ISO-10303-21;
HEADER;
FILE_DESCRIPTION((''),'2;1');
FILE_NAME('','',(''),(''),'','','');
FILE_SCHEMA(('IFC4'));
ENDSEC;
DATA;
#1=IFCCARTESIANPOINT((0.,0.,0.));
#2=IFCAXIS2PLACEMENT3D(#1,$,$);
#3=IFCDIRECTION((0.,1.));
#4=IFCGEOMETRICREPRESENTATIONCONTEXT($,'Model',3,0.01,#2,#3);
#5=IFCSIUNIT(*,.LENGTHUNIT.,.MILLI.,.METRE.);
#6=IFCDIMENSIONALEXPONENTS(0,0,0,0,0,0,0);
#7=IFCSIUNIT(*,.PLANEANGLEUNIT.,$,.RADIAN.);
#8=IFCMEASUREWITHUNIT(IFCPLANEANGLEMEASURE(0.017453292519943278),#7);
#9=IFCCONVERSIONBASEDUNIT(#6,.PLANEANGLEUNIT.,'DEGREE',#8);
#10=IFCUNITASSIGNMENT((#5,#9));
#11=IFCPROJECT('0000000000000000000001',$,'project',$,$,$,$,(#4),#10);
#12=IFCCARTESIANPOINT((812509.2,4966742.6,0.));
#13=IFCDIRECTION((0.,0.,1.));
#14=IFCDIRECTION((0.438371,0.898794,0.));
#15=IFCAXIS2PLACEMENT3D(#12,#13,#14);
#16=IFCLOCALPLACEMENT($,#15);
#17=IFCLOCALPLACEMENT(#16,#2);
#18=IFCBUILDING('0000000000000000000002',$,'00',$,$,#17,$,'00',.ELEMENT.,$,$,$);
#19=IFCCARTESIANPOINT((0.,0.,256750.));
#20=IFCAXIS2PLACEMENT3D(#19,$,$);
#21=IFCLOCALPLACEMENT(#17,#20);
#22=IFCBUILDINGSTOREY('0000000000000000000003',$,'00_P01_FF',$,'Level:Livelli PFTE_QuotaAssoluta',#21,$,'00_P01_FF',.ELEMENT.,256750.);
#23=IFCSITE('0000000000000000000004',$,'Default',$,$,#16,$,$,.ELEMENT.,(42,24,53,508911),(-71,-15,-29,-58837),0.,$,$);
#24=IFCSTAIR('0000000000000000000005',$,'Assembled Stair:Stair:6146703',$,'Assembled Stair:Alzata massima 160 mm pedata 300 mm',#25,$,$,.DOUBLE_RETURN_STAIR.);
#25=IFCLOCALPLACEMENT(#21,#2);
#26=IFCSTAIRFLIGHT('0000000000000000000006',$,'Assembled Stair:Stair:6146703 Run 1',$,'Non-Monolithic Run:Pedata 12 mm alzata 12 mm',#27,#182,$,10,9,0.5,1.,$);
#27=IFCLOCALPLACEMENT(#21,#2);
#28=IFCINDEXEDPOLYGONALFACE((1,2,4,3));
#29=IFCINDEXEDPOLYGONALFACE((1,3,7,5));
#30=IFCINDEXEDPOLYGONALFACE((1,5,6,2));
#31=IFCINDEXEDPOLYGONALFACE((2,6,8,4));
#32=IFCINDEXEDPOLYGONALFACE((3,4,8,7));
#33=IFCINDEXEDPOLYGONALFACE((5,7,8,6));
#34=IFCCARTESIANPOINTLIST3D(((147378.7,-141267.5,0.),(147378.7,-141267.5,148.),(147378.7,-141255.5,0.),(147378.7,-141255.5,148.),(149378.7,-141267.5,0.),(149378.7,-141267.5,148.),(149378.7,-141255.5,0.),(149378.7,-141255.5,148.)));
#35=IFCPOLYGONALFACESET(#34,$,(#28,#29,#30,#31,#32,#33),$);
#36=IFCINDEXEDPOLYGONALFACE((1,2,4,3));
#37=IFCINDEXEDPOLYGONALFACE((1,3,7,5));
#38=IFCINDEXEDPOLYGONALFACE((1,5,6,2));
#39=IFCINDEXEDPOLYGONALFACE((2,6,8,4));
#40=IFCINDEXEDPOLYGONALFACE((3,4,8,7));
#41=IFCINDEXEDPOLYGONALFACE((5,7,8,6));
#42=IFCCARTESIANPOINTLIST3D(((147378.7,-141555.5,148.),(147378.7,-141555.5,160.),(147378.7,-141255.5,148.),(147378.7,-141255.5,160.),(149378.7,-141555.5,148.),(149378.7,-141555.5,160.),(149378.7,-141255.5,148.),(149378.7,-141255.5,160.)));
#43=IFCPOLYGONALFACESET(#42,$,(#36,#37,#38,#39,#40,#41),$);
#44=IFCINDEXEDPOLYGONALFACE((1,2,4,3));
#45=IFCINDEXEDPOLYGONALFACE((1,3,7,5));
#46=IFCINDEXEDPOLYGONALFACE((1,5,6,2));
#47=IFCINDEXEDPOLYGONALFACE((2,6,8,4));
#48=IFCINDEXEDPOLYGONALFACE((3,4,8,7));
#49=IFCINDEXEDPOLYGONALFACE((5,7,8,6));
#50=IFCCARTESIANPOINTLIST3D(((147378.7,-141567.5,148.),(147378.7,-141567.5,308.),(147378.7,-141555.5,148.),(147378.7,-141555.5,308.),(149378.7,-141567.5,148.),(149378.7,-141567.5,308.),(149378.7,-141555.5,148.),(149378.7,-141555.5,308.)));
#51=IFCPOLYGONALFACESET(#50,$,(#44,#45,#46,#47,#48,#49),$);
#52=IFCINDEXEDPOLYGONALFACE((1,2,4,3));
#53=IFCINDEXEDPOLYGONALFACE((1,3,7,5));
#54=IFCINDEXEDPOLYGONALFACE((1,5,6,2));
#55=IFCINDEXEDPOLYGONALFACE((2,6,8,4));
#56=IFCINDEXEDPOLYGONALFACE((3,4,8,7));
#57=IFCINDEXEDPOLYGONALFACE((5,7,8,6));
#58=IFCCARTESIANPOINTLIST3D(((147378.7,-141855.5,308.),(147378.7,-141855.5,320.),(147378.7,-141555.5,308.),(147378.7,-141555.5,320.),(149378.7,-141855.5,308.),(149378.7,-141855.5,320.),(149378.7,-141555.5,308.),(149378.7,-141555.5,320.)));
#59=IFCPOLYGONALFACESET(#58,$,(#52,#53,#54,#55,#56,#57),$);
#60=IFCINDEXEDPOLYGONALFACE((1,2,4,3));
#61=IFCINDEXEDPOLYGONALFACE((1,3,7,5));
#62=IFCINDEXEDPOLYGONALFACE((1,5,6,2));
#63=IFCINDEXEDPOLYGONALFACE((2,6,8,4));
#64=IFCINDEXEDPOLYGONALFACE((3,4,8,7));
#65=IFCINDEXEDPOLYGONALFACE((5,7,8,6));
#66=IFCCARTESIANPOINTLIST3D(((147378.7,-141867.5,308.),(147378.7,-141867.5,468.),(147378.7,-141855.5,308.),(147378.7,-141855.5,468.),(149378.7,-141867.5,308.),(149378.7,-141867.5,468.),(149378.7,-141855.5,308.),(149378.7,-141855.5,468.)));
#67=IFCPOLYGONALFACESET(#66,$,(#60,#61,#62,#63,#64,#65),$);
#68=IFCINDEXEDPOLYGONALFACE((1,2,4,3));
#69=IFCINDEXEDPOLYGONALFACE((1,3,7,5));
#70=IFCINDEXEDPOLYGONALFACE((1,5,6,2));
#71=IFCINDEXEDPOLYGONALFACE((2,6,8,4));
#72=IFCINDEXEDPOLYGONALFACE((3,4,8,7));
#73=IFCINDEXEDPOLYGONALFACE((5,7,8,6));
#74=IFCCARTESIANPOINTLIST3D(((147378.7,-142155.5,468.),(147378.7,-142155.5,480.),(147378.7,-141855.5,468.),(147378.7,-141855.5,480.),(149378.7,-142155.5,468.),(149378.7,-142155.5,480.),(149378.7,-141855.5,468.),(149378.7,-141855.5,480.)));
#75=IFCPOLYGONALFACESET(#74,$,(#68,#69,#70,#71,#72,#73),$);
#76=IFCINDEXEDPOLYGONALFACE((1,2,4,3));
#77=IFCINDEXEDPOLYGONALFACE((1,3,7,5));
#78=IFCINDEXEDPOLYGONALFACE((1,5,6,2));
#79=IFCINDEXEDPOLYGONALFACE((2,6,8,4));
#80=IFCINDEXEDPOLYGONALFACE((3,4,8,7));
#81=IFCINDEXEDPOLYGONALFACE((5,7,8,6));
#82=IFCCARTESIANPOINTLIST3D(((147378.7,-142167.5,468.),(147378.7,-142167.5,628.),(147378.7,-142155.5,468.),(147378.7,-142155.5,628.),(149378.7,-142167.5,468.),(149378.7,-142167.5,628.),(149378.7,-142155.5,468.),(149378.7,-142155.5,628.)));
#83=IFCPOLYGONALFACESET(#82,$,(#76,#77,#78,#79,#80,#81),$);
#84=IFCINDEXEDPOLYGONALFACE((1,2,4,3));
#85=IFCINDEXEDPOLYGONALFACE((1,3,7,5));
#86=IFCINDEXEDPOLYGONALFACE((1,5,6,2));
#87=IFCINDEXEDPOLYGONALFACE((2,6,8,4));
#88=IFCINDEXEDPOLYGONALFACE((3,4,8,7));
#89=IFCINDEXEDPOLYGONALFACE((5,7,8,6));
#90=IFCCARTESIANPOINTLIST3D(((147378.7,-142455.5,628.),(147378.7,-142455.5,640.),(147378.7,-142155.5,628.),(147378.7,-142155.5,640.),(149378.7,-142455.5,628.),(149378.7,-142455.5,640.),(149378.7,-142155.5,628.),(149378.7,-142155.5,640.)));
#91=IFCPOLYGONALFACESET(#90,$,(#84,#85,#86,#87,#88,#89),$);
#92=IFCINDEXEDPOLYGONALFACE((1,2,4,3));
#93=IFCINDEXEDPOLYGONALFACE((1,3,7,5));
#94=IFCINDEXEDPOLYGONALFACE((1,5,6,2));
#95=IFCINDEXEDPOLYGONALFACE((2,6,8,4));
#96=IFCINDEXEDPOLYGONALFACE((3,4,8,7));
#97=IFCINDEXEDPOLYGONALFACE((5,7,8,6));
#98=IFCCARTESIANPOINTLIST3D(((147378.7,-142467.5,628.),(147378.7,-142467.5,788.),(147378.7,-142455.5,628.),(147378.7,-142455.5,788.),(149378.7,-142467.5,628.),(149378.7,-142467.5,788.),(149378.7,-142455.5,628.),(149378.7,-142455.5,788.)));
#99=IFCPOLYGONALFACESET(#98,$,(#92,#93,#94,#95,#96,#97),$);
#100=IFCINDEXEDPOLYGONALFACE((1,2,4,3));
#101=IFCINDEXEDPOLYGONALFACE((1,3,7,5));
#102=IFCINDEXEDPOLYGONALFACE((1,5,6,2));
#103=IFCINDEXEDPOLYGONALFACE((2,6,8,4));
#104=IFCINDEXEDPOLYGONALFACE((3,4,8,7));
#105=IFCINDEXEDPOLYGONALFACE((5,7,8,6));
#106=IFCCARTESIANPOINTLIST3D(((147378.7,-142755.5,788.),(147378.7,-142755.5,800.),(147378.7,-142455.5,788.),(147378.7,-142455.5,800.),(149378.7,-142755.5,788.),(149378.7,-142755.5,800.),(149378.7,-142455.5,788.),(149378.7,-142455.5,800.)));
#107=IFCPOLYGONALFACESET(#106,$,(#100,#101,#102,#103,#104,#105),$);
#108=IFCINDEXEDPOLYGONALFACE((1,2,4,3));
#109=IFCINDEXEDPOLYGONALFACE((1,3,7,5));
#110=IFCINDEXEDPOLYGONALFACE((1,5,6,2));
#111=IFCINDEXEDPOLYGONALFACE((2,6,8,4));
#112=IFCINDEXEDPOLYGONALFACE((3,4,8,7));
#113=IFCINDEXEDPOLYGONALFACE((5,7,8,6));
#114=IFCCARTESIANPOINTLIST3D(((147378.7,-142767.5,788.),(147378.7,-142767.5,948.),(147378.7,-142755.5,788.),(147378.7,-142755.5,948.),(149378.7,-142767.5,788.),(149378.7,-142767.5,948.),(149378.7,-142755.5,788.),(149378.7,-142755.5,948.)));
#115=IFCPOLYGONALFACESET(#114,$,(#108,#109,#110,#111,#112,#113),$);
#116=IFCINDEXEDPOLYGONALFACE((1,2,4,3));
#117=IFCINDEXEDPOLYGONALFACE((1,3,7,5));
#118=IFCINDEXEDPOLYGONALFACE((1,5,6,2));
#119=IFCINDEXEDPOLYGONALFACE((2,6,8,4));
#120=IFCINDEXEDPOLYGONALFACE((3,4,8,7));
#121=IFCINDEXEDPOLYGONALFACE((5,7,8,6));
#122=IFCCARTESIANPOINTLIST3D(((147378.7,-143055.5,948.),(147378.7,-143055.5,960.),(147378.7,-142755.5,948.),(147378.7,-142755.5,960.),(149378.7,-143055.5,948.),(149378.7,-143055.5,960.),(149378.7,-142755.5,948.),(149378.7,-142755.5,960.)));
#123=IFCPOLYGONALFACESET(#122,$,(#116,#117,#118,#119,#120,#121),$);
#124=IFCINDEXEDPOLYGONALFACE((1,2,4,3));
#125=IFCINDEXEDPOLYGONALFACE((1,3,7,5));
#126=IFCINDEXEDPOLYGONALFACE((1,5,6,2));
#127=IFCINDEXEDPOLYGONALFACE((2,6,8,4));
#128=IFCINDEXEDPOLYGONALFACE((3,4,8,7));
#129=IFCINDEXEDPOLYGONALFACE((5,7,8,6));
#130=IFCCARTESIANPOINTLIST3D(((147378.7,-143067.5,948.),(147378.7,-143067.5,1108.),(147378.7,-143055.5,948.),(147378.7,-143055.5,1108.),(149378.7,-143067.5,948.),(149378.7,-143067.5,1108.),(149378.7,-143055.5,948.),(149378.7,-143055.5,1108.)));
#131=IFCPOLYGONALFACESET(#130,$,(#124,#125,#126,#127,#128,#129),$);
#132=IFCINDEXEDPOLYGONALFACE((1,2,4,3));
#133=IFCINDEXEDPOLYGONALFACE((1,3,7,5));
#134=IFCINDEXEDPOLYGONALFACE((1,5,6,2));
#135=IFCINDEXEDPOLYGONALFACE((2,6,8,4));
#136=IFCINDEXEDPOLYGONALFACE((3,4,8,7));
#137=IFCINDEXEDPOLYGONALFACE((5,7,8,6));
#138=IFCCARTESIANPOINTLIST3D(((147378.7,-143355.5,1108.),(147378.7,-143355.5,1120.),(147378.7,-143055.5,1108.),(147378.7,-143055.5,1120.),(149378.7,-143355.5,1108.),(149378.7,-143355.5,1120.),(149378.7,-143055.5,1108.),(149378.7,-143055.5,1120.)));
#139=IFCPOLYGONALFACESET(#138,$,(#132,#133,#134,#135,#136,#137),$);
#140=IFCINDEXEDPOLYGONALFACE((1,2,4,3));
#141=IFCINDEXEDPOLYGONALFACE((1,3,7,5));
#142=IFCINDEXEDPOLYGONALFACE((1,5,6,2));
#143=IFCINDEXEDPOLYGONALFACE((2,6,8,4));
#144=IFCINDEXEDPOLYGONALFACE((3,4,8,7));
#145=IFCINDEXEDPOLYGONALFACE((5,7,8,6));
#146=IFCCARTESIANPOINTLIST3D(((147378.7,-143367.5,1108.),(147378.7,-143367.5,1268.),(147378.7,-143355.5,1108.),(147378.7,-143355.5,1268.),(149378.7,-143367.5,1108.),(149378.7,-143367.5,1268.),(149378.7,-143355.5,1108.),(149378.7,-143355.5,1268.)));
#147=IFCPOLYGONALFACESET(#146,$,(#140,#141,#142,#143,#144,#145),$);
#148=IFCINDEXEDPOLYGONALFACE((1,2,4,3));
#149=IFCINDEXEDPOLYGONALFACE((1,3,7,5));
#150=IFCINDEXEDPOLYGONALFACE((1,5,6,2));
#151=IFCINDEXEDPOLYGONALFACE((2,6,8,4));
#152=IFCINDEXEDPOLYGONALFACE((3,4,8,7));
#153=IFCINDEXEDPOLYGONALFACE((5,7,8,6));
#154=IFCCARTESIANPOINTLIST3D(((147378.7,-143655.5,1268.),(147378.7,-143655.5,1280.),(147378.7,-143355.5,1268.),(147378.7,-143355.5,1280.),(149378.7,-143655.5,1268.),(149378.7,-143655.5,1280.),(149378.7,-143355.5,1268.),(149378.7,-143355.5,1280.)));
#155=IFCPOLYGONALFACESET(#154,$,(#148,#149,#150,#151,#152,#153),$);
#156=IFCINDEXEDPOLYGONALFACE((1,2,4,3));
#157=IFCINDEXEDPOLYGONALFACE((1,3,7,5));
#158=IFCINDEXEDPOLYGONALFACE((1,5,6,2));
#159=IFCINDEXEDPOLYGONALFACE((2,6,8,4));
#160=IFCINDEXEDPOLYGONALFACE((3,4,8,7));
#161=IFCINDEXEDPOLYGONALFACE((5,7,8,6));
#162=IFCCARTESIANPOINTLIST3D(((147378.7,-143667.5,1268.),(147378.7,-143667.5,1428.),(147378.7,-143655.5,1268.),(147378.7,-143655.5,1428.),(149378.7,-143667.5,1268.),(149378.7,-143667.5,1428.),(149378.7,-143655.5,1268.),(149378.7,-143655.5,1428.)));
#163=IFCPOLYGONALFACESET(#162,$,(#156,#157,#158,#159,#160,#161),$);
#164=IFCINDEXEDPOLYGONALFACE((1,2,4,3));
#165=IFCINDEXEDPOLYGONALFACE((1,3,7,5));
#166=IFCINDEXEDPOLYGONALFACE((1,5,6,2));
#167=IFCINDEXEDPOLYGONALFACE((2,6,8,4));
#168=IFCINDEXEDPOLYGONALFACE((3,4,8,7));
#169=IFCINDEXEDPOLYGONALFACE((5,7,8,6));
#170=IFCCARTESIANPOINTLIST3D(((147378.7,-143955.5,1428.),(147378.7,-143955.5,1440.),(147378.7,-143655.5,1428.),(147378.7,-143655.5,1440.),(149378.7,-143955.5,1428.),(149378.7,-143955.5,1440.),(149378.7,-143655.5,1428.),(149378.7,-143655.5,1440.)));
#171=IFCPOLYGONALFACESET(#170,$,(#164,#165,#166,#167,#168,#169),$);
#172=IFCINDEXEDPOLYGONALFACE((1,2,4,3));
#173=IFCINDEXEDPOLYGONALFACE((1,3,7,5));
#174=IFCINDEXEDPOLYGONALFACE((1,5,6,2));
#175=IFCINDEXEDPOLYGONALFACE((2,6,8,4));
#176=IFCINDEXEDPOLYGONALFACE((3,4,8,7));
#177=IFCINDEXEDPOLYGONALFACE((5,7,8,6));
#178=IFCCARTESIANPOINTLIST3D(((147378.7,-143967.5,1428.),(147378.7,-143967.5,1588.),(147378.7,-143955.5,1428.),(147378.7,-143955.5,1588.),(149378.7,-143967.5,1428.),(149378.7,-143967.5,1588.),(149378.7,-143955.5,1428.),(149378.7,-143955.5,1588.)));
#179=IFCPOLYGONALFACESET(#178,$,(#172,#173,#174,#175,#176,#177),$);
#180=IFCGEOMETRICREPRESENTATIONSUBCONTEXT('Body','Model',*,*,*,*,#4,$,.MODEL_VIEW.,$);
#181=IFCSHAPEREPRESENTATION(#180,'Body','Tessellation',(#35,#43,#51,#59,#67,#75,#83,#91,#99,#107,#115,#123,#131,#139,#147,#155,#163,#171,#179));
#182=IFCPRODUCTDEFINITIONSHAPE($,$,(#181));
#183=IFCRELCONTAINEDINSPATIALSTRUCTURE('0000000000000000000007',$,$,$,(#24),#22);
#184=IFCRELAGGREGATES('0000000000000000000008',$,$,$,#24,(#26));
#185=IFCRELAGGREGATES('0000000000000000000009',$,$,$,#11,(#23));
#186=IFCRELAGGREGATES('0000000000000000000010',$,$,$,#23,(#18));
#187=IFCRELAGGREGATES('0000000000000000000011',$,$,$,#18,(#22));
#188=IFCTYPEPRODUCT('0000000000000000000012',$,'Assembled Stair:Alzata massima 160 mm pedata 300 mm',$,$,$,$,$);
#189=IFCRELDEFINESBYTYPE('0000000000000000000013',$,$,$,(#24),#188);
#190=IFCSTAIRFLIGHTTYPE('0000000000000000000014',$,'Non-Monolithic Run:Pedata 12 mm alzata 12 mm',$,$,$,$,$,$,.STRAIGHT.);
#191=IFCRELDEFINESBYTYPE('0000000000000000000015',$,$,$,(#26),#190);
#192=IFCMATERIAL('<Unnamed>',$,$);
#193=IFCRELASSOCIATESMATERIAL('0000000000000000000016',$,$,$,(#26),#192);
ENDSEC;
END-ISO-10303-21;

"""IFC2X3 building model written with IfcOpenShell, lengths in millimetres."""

from ifc_helpers import new_model, entity, si_unit, converted_unit, direction, frame, frame_2d, origin, origin_2d_with_axis, place, context, subcontext, project, spatial, rectangle, extrude, material, type_object, element, aggregate, save


model = new_model("IFC2X3")

# Units and contexts
model_context = context("Model", 3, precision=0.01, world=origin(), true_north=direction((0.0, 1.0)))
body_context = subcontext(model_context, "Body", "Model", "MODEL_VIEW")
ifc_project = project(units=[si_unit("LENGTHUNIT", "METRE", prefix="MILLI"), converted_unit("PLANEANGLEUNIT", "DEGREE", entity("IfcPlaneAngleMeasure", 0.017453292519943278), si_unit("PLANEANGLEUNIT", "RADIAN"), dimensions=[0, 0, 0, 0, 0, 0, 0])], contexts=[model_context])

# Site, building, storey
site_placement = place(None, frame((812509.2, 4966742.6, 0.0), z_axis=(0.0, 0.0, 1.0), x_axis=(0.438371, 0.898794, 0.0)))
site = spatial("IfcSite", under=ifc_project, at=site_placement, Name="Default", CompositionType="ELEMENT", RefLatitude=(42, 24, 53, 508911), RefLongitude=(-71, -15, -29, -58837), RefElevation=0.0)
building_placement = place(site_placement, origin())
building = spatial("IfcBuilding", under=site, at=building_placement, Name="00", LongName="00", CompositionType="ELEMENT")
storey_placement = place(building_placement, frame((0.0, 0.0, 256750.0)))
storey = spatial("IfcBuildingStorey", under=building, at=storey_placement, Name="00_P01_FF", ObjectType="Level:Livelli PFTE_QuotaAssoluta", LongName="00_P01_FF", CompositionType="ELEMENT", Elevation=256750.0)

# Stair
type_product = type_object("IfcTypeProduct", Name="Assembled Stair:Alzata massima 160 mm pedata 300 mm")
stair_1_placement = place(storey_placement, origin())
stair_1 = element("IfcStair", 1, at=stair_1_placement, inside=storey, type_object=type_product, Name="Assembled Stair:Stair:6146703", ObjectType="Assembled Stair:Alzata massima 160 mm pedata 300 mm", ShapeType="DOUBLE_RETURN_STAIR")
ifc_material = material(Name="<Unnamed>")

# Stair flight
stair_flight_type = type_object("IfcStairFlightType", Name="Non-Monolithic Run:Pedata 12 mm alzata 12 mm", PredefinedType="STRAIGHT")
stair_flight_1_placement = place(stair_1_placement, origin())
stair_flight_1 = element("IfcStairFlight", 2, at=stair_flight_1_placement, type_object=stair_flight_type, material=ifc_material, Name="Assembled Stair:Stair:6146703 Run 1", ObjectType="Non-Monolithic Run:Pedata 12 mm alzata 12 mm", NumberOfRiser=10, NumberOfTreads=9, RiserHeight=0.5, TreadLength=1.0, context=body_context, shape_type="SweptSolid", body=[
    extrude(rectangle(XDim=2000.0, YDim=12.0, at=origin_2d_with_axis()), frame((148378.7, -141261.5, 0.0)), (0.0, 0.0, 1.0), 148.0),
    extrude(rectangle(XDim=300.0, YDim=2000.0, at=frame_2d((0.0, 0.0), x_axis=(1.0, 0.0))), frame((148378.7, -141405.5, 148.0), z_axis=(0.0, 0.0, 1.0), x_axis=(0.0, 1.0, 0.0)), (0.0, 0.0, 1.0), 12.0),
    extrude(rectangle(XDim=2000.0, YDim=12.0, at=origin_2d_with_axis()), frame((148378.7, -141561.5, 148.0)), (0.0, 0.0, 1.0), 160.0),
    extrude(rectangle(XDim=300.0, YDim=2000.0, at=origin_2d_with_axis()), frame((148378.7, -141705.5, 308.0), z_axis=(0.0, 0.0, 1.0), x_axis=(0.0, 1.0, 0.0)), (0.0, 0.0, 1.0), 12.0),
    extrude(rectangle(XDim=2000.0, YDim=12.0, at=origin_2d_with_axis()), frame((148378.7, -141861.5, 308.0)), (0.0, 0.0, 1.0), 160.0),
    extrude(rectangle(XDim=300.0, YDim=2000.0, at=origin_2d_with_axis()), frame((148378.7, -142005.5, 468.0), z_axis=(0.0, 0.0, 1.0), x_axis=(0.0, 1.0, 0.0)), (0.0, 0.0, 1.0), 12.0),
    extrude(rectangle(XDim=2000.0, YDim=12.0, at=origin_2d_with_axis()), frame((148378.7, -142161.5, 468.0)), (0.0, 0.0, 1.0), 160.0),
    extrude(rectangle(XDim=300.0, YDim=2000.0, at=origin_2d_with_axis()), frame((148378.7, -142305.5, 628.0), z_axis=(0.0, 0.0, 1.0), x_axis=(0.0, 1.0, 0.0)), (0.0, 0.0, 1.0), 12.0),
    extrude(rectangle(XDim=2000.0, YDim=12.0, at=origin_2d_with_axis()), frame((148378.7, -142461.5, 628.0)), (0.0, 0.0, 1.0), 160.0),
    extrude(rectangle(XDim=300.0, YDim=2000.0, at=origin_2d_with_axis()), frame((148378.7, -142605.5, 788.0), z_axis=(0.0, 0.0, 1.0), x_axis=(0.0, 1.0, 0.0)), (0.0, 0.0, 1.0), 12.0),
    extrude(rectangle(XDim=2000.0, YDim=12.0, at=origin_2d_with_axis()), frame((148378.7, -142761.5, 788.0)), (0.0, 0.0, 1.0), 160.0),
    extrude(rectangle(XDim=300.0, YDim=2000.0, at=origin_2d_with_axis()), frame((148378.7, -142905.5, 948.0), z_axis=(0.0, 0.0, 1.0), x_axis=(0.0, 1.0, 0.0)), (0.0, 0.0, 1.0), 12.0),
    extrude(rectangle(XDim=2000.0, YDim=12.0, at=origin_2d_with_axis()), frame((148378.7, -143061.5, 948.0)), (0.0, 0.0, 1.0), 160.0),
    extrude(rectangle(XDim=300.0, YDim=2000.0, at=origin_2d_with_axis()), frame((148378.7, -143205.5, 1108.0), z_axis=(0.0, 0.0, 1.0), x_axis=(0.0, 1.0, 0.0)), (0.0, 0.0, 1.0), 12.0),
    extrude(rectangle(XDim=2000.0, YDim=12.0, at=origin_2d_with_axis()), frame((148378.7, -143361.5, 1108.0)), (0.0, 0.0, 1.0), 160.0),
    extrude(rectangle(XDim=300.0, YDim=2000.0, at=origin_2d_with_axis()), frame((148378.7, -143505.5, 1268.0), z_axis=(0.0, 0.0, 1.0), x_axis=(0.0, 1.0, 0.0)), (0.0, 0.0, 1.0), 12.0),
    extrude(rectangle(XDim=2000.0, YDim=12.0, at=origin_2d_with_axis()), frame((148378.7, -143661.5, 1268.0)), (0.0, 0.0, 1.0), 160.0),
    extrude(rectangle(XDim=300.0, YDim=2000.0, at=origin_2d_with_axis()), frame((148378.7, -143805.5, 1428.0), z_axis=(0.0, 0.0, 1.0), x_axis=(0.0, 1.0, 0.0)), (0.0, 0.0, 1.0), 12.0),
    extrude(rectangle(XDim=2000.0, YDim=12.0, at=origin_2d_with_axis()), frame((148378.7, -143961.5, 1428.0)), (0.0, 0.0, 1.0), 160.0),
])
aggregate(stair_1, [stair_flight_1])

save(model, "model.ifc")
